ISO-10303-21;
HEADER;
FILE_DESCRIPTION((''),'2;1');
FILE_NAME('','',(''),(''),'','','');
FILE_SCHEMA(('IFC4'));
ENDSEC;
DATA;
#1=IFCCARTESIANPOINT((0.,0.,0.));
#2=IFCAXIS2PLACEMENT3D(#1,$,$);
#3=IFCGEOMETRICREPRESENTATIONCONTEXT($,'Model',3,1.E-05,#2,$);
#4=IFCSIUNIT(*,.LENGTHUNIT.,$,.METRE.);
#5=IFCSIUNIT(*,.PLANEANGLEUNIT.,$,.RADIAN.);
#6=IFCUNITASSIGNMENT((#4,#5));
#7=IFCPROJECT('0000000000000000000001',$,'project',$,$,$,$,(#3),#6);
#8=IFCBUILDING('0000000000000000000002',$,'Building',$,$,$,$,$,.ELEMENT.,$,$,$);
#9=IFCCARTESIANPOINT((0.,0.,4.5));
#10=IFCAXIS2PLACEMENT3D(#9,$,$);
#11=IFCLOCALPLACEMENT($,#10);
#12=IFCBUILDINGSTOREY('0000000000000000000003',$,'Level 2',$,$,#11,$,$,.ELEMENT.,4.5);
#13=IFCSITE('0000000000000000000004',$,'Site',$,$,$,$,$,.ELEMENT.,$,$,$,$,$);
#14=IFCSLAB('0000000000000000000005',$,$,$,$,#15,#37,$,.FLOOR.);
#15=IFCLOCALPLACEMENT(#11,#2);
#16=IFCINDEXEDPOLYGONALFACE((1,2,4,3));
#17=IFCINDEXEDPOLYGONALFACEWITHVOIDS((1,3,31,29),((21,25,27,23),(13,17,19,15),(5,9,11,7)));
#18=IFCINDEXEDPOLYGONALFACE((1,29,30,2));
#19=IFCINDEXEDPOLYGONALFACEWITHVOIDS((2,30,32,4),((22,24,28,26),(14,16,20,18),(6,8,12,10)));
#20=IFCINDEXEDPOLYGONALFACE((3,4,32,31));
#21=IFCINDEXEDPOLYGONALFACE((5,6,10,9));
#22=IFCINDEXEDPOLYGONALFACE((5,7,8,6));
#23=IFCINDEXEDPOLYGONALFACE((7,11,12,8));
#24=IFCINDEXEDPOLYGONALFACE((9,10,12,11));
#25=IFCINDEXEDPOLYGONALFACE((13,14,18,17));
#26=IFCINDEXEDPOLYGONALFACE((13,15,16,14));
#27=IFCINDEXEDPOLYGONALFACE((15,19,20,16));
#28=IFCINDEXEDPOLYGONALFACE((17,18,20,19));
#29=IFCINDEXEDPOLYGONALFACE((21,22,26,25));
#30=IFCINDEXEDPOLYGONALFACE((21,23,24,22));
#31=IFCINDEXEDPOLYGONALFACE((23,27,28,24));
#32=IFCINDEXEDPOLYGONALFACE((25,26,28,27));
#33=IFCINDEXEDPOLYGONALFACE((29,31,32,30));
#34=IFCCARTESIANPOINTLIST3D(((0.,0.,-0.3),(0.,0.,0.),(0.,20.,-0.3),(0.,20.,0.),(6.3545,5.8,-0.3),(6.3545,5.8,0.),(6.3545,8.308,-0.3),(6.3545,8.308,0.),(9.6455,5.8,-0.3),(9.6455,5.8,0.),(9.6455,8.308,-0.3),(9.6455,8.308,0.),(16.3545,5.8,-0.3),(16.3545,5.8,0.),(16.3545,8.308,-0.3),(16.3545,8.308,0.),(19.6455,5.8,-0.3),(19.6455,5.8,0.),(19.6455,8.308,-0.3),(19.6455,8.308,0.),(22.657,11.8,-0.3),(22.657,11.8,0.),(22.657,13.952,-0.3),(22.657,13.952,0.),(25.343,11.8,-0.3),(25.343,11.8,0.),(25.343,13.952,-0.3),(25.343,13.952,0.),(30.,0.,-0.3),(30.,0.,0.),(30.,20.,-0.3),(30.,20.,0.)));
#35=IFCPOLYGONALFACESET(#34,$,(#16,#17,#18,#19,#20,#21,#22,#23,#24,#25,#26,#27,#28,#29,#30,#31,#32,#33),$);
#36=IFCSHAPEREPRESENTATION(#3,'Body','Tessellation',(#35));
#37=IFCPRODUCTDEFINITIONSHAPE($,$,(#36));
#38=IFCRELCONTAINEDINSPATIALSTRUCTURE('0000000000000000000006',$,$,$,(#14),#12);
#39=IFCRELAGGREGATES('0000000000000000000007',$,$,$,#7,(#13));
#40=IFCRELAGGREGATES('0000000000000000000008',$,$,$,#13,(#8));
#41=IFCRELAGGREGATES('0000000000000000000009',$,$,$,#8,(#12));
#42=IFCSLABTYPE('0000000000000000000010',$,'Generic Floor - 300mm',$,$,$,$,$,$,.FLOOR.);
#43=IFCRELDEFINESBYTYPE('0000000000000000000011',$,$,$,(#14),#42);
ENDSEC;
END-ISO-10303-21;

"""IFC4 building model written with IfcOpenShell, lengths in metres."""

from ifc_helpers import new_model, si_unit, frame, origin, place, context, project, spatial, polyline, outline, extrude, type_object, element, save


model = new_model("IFC4")

# Units and contexts
model_context = context("Model", 3, precision=1e-05, world=origin())
ifc_project = project(units=[si_unit("LENGTHUNIT", "METRE"), si_unit("PLANEANGLEUNIT", "RADIAN")], contexts=[model_context])

# Site, building, storey
site = spatial("IfcSite", under=ifc_project, Name="Site", CompositionType="ELEMENT")
building = spatial("IfcBuilding", under=site, Name="Building", CompositionType="ELEMENT")
storey_placement = place(None, frame((0.0, 0.0, 4.5)))
storey = spatial("IfcBuildingStorey", under=building, at=storey_placement, Name="Level 2", CompositionType="ELEMENT", Elevation=4.5)

# Slab, openings
slab_type = type_object("IfcSlabType", Name="Generic Floor - 300mm", PredefinedType="FLOOR")
slab_placement = place(None, frame((0.0, 0.0, 4.5)))
slab = element("IfcSlab", 1, at=slab_placement, inside=storey, type_object=slab_type, PredefinedType="FLOOR", context=model_context, shape_type="SweptSolid", body=[
    extrude(outline(polyline([(0.0, 0.0), (30.0, 0.0), (30.0, 20.0), (0.0, 20.0), (0.0, 0.0)])), origin(), (0.0, 0.0, -1.0), 0.3),
])
opening_1_placement = place(None, frame((0.0, 0.0, 4.501)))
element("IfcOpeningElement", 2, at=opening_1_placement, cuts=slab, PredefinedType="OPENING", context=model_context, shape_type="SweptSolid", body=[
    extrude(outline(polyline([(6.3545, 5.8), (9.6455, 5.8), (9.6455, 8.308), (6.3545, 8.308), (6.3545, 5.8)])), origin(), (0.0, 0.0, -1.0), 0.302),
])
opening_2_placement = place(None, frame((0.0, 0.0, 4.501)))
element("IfcOpeningElement", 3, at=opening_2_placement, cuts=slab, PredefinedType="OPENING", context=model_context, shape_type="SweptSolid", body=[
    extrude(outline(polyline([(16.3545, 5.8), (19.6455, 5.8), (19.6455, 8.308), (16.3545, 8.308), (16.3545, 5.8)])), origin(), (0.0, 0.0, -1.0), 0.302),
])
opening_3_placement = place(None, frame((0.0, 0.0, 4.501)))
element("IfcOpeningElement", 4, at=opening_3_placement, cuts=slab, PredefinedType="OPENING", context=model_context, shape_type="SweptSolid", body=[
    extrude(outline(polyline([(22.657, 11.8), (25.343, 11.8), (25.343, 13.952), (22.657, 13.952), (22.657, 11.8)])), origin(), (0.0, 0.0, -1.0), 0.302),
])

save(model, "model.ifc")
